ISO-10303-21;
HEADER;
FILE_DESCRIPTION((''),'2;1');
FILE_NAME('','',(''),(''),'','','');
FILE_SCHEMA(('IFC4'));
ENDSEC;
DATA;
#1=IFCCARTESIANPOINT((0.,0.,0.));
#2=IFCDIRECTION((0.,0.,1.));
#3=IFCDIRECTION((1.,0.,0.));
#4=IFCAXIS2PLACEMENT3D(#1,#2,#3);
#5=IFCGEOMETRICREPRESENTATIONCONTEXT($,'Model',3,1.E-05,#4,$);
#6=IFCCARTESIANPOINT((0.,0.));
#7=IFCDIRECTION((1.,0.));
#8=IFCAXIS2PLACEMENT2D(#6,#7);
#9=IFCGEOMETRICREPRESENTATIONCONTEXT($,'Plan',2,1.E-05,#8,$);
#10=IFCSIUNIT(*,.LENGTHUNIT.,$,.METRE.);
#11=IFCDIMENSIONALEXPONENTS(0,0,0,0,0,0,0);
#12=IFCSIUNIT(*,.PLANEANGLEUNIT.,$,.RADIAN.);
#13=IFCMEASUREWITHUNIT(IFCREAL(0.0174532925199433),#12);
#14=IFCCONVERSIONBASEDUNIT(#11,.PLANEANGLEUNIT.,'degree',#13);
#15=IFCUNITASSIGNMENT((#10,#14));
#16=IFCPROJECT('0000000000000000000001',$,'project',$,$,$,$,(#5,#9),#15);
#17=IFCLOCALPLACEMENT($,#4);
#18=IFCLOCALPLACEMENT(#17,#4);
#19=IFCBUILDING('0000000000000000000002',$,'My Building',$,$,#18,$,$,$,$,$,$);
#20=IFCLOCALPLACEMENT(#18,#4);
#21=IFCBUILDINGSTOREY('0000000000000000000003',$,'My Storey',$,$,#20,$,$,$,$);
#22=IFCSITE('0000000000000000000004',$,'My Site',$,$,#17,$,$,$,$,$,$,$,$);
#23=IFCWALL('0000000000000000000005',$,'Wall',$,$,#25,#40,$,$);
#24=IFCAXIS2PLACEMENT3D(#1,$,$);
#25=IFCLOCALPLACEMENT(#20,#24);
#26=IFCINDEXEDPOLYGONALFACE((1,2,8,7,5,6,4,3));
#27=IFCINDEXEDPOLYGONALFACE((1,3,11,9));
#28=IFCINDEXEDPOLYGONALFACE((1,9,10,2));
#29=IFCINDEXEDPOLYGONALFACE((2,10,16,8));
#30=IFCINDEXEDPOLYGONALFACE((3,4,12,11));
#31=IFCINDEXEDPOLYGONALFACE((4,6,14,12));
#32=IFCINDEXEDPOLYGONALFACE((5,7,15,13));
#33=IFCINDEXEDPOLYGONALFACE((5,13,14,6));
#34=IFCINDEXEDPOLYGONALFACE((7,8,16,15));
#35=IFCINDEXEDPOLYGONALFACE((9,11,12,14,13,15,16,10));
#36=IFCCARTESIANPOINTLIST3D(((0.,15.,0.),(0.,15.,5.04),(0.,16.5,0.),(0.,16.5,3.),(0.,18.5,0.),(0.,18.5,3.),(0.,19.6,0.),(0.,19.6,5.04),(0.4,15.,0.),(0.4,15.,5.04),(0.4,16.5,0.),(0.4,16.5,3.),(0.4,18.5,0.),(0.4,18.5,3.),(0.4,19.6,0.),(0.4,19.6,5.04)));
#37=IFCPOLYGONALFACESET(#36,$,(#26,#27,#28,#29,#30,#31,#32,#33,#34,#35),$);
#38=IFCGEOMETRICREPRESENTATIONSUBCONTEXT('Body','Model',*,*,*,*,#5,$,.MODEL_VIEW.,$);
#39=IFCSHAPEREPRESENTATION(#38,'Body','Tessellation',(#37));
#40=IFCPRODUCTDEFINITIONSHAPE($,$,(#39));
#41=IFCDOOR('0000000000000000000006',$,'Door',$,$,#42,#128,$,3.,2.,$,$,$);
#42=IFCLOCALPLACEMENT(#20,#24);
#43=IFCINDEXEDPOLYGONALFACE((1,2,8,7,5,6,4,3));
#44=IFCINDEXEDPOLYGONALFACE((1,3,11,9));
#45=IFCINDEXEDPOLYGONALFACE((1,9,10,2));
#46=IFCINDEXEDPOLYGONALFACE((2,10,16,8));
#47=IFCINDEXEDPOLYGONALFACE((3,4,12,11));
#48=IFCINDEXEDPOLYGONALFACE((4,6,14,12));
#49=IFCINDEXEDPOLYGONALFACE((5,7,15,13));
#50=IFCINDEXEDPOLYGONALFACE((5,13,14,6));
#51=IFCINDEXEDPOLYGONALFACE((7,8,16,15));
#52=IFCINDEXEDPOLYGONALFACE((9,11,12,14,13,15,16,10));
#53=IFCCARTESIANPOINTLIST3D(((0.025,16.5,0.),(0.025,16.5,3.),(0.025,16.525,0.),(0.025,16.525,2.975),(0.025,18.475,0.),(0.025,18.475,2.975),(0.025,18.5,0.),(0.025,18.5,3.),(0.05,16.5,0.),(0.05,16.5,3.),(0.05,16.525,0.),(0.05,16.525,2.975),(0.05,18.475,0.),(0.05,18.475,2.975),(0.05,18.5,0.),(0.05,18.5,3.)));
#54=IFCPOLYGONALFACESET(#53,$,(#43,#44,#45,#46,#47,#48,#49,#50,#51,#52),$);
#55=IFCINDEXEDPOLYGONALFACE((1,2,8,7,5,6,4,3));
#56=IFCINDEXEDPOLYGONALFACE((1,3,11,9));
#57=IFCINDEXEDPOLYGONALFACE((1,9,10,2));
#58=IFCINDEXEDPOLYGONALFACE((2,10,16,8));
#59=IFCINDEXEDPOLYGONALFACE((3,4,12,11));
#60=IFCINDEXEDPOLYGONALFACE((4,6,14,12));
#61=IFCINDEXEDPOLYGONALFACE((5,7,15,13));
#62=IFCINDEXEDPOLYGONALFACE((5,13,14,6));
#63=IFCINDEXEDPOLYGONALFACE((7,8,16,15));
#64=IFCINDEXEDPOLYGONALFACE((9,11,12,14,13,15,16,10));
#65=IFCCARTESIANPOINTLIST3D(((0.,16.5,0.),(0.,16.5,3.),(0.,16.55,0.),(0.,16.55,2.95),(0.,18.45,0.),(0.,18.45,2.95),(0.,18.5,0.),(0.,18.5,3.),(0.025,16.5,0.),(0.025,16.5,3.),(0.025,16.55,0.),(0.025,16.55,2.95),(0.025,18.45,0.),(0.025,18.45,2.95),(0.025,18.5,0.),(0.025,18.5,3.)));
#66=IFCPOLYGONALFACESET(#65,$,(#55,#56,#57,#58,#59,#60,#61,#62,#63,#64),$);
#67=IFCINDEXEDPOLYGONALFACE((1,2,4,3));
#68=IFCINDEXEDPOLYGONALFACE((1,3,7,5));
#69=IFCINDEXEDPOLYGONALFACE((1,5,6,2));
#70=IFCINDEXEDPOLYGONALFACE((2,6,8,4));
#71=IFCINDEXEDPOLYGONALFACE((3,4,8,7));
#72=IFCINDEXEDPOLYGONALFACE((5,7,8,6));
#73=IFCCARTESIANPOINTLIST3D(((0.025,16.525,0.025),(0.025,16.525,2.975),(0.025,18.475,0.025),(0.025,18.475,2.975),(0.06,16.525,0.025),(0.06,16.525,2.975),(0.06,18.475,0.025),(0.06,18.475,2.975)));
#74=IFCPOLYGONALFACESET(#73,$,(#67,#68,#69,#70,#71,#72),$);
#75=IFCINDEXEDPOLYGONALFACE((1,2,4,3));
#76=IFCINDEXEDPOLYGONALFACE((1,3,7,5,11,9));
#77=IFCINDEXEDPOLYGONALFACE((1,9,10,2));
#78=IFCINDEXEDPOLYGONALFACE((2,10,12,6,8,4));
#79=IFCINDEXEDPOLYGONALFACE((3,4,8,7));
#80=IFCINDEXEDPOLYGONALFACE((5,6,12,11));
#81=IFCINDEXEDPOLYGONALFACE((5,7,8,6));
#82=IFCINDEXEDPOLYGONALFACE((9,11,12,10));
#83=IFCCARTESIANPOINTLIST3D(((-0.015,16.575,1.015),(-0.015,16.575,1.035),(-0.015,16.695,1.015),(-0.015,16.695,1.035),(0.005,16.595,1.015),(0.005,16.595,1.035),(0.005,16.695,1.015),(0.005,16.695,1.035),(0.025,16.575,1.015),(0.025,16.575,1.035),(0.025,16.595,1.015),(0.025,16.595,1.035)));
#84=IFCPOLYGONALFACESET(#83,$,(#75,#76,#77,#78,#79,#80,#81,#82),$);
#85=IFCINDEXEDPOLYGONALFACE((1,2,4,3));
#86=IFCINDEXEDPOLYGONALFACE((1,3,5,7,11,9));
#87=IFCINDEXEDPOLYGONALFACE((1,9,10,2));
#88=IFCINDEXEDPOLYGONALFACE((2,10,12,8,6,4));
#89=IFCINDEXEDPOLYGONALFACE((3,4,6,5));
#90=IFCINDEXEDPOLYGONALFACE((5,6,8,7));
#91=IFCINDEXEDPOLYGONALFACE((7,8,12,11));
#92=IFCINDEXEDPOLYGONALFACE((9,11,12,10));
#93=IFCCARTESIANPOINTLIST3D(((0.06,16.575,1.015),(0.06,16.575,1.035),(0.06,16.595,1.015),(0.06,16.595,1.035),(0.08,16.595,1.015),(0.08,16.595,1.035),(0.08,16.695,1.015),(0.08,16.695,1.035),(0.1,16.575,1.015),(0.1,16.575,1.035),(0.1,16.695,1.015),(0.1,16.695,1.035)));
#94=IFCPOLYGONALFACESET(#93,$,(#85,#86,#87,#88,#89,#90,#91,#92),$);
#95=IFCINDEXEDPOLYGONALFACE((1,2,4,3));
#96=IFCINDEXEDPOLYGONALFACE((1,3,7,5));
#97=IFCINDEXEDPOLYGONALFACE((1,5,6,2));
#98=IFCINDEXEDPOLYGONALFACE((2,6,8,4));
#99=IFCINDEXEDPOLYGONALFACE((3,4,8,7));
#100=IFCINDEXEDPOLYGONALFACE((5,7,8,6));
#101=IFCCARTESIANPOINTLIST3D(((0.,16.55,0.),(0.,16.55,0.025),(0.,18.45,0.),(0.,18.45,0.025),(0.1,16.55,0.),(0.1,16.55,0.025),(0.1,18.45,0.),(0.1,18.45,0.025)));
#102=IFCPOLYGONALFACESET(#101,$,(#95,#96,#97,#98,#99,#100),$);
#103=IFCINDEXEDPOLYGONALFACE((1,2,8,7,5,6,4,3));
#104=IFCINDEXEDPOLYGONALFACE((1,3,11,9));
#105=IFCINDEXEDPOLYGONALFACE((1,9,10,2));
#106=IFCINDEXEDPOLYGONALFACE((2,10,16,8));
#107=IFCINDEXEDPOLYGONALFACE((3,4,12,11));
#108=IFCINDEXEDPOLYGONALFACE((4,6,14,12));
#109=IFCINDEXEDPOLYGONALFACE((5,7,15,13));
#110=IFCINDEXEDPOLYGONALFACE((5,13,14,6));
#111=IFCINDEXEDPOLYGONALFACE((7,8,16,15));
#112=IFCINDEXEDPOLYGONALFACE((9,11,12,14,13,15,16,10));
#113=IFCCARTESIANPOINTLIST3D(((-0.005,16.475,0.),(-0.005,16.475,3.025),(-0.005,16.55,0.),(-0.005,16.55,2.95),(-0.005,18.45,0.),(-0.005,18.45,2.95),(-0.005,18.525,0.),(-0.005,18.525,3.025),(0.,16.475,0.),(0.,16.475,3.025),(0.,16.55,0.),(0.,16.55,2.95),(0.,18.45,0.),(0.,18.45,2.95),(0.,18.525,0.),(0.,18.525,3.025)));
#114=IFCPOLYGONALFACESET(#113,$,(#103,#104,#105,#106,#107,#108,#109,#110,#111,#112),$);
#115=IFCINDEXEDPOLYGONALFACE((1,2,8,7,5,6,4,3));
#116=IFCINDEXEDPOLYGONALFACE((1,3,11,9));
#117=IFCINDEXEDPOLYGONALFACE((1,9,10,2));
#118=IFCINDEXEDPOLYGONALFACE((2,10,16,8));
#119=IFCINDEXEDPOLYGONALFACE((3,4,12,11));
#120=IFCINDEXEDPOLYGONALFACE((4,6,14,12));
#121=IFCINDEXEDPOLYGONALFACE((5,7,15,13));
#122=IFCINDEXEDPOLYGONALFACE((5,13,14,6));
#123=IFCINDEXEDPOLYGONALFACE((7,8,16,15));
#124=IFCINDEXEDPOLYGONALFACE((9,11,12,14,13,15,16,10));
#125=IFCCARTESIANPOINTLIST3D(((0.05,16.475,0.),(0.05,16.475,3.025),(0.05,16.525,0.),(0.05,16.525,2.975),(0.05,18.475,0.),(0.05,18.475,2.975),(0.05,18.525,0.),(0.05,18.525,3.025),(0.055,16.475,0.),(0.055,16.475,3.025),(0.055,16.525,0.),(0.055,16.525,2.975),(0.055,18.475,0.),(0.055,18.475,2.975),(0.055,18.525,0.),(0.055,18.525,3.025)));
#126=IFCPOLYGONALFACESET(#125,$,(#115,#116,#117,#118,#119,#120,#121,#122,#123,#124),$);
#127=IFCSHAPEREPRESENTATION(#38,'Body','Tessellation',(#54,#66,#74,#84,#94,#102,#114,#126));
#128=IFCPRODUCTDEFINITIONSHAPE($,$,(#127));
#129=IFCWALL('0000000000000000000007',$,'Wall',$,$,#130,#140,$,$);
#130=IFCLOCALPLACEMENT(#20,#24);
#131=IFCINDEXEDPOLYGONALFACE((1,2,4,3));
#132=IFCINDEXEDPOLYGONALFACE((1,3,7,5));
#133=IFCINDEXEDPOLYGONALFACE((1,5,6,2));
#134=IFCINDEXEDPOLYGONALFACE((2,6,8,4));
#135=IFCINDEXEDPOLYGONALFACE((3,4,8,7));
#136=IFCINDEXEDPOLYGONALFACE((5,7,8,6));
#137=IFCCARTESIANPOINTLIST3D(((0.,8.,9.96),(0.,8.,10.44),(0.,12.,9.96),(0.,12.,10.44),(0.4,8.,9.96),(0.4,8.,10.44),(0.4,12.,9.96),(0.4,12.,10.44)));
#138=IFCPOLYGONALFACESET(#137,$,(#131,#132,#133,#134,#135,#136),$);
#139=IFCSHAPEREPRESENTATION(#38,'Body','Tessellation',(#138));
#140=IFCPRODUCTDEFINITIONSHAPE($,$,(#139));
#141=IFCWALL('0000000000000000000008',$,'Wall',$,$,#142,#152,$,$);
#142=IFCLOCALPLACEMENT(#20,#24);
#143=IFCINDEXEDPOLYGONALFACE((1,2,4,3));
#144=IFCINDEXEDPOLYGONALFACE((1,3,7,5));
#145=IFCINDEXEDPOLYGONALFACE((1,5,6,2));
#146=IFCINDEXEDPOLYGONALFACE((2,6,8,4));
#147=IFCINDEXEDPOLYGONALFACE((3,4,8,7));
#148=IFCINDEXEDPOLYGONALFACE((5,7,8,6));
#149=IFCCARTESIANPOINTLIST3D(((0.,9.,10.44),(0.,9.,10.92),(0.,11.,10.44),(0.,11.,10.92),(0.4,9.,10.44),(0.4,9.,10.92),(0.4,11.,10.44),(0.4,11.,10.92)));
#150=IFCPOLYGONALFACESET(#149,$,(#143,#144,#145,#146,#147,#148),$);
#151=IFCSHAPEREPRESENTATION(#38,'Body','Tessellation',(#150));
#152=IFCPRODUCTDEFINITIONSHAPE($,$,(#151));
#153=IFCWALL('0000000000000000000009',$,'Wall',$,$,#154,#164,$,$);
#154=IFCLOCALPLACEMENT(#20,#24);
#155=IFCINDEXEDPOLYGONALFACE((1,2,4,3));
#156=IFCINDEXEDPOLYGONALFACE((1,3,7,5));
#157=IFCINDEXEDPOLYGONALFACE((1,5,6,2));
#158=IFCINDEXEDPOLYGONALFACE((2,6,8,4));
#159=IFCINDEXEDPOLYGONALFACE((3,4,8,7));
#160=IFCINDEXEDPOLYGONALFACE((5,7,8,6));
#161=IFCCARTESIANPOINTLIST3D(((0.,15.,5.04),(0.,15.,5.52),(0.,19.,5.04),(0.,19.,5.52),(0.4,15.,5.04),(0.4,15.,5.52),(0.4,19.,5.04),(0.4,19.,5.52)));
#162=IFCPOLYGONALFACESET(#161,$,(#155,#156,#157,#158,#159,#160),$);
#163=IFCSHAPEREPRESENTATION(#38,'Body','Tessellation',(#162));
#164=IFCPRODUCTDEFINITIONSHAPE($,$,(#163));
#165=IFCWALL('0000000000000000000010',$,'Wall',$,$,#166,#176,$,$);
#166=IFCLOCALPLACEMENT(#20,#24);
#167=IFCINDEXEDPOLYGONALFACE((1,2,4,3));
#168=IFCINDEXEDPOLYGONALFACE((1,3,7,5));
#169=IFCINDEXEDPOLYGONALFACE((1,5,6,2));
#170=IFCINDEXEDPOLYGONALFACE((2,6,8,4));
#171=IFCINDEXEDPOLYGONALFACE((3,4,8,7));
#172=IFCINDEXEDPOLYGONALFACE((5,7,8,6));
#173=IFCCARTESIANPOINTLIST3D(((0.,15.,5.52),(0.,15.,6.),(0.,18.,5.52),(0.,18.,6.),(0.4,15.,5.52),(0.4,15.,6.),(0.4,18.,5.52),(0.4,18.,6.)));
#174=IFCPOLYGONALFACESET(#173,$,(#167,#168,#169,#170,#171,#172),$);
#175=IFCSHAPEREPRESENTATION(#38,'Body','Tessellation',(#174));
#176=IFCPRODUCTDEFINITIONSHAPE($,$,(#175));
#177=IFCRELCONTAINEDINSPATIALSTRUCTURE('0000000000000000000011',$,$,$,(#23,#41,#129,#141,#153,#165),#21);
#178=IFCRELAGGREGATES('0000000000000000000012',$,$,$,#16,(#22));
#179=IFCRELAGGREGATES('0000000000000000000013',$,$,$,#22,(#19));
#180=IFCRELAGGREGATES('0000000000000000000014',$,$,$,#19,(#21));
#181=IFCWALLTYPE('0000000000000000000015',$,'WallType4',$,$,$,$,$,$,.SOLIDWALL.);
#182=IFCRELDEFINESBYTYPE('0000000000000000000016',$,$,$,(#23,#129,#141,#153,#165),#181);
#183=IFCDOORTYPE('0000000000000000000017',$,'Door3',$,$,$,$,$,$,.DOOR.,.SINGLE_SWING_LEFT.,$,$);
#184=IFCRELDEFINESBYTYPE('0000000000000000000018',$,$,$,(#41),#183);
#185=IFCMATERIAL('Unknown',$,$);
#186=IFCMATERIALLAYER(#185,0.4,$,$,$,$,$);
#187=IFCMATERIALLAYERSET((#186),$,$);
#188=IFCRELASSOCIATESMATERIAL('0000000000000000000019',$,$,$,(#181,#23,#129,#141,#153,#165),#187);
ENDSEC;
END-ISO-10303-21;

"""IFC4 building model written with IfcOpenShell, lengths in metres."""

from ifc_helpers import new_model, entity, si_unit, converted_unit, frame, origin_with_axes, origin_2d_with_axis, place, context, subcontext, project, spatial, line, indexed_curve, outline, extrude, shape, source, transform, mapped, material, layer, layer_set, layer_usage, type_object, type_shapes, element, fill, save


model = new_model("IFC4")

# Units and contexts
model_context = context("Model", 3, precision=1e-05, world=origin_with_axes())
plan_context = context("Plan", 2, precision=1e-05, world=origin_2d_with_axis())
body_context_1 = subcontext(model_context, "Body", "Model", "MODEL_VIEW")
body_context_2 = subcontext(plan_context, "Body", "Plan", "PLAN_VIEW")
ifc_project = project(units=[si_unit("LENGTHUNIT", "METRE"), converted_unit("PLANEANGLEUNIT", "degree", entity("IfcReal", 0.0174532925199433), si_unit("PLANEANGLEUNIT", "RADIAN"), dimensions=[0, 0, 0, 0, 0, 0, 0])], contexts=[model_context, plan_context])

# Site, building, storey
site_placement = place(None, origin_with_axes())
site = spatial("IfcSite", under=ifc_project, at=site_placement, Name="My Site")
building_placement = place(site_placement, origin_with_axes())
building = spatial("IfcBuilding", under=site, at=building_placement, Name="My Building")
storey_placement = place(building_placement, origin_with_axes())
storey = spatial("IfcBuildingStorey", under=building, at=storey_placement, Name="My Storey")

# Shared definitions
ifc_material = material(Name="Unknown")

# Shared definitions
ifc_layer_1 = layer(ifc_material, 0.4)
ifc_layer_set_1 = layer_set([ifc_layer_1])
wall_type_1 = type_object("IfcWallType", Name="WallType4", PredefinedType="SOLIDWALL", material=ifc_layer_set_1)

# Wall, opening, door
ifc_layer_usage_1 = layer_usage(ifc_layer_set_1, "AXIS2", "POSITIVE", 0.0)
wall_1_placement = place(storey_placement, frame((0.0, 19.6, 0.0), z_axis=(0.0, 0.0, 1.0), x_axis=(0.0, -1.0, 0.0)))
wall_1 = element("IfcWall", 1, at=wall_1_placement, inside=storey, type_object=wall_type_1, material=ifc_layer_usage_1, Name="Wall", context=body_context_1, shape_type="SweptSolid", body=[
    extrude(outline(indexed_curve([(0.0, 0.0), (0.0, 0.4), (4.6, 0.4), (4.6, 0.0), (0.0, 0.0)], self_intersect=False)), origin_with_axes(), (0.0, 0.0, 1.0), 5.04),
])
shared_shape_1 = source(origin_with_axes(), body_context_1, "Body", "SweptSolid", [
    extrude(outline(indexed_curve([(0.0, 0.0), (2.0, 0.0), (2.0, 3.0), (0.0, 3.0)], segments=[line(1, 2, 3, 4, 1)])), frame((0.0, -0.6, 0.0), z_axis=(0.0, -1.0, 0.0), x_axis=(1.0, 0.0, 0.0)), (0.0, 0.0, -1.0), 1.2),
])
opening_1_placement = place(wall_1_placement, frame((1.1, 0.0, 0.0), z_axis=(0.0, 0.0, 1.0), x_axis=(1.0, 0.0, 0.0)))
opening_1 = element("IfcOpeningElement", 2, at=opening_1_placement, cuts=wall_1, PredefinedType="OPENING", context=body_context_1, shape_type="MappedRepresentation", body=[
    mapped(shared_shape_1, transform((0.0, 0.0, 0.0), x_axis=(1.0, 0.0, 0.0), y_axis=(0.0, 1.0, 0.0), z_axis=(0.0, 0.0, 1.0), scale=1.0)),
])
door_type_1 = type_object("IfcDoorType", Name="Door3", OperationType="SINGLE_SWING_LEFT", PredefinedType="DOOR")
shared_shape_2 = source(origin_with_axes(), body_context_1, "Body", "SweptSolid", [
    extrude(outline(indexed_curve([(0.0, 0.0), (0.0, 3.0), (2.0, 3.0), (2.0, 0.0), (1.975, 0.0), (1.975, 2.975), (0.025, 2.975), (0.025, 0.0)], segments=[line(1, 2, 3, 4, 5, 6, 7, 8, 1)])), frame((0.0, 0.025, 0.0), z_axis=(0.0, -1.0, 0.0), x_axis=(1.0, 0.0, 0.0)), (0.0, 0.0, -1.0), 0.025),
    extrude(outline(indexed_curve([(0.0, 0.0), (0.0, 3.0), (2.0, 3.0), (2.0, 0.0), (1.95, 0.0), (1.95, 2.95), (0.05, 2.95), (0.05, 0.0)], segments=[line(1, 2, 3, 4, 5, 6, 7, 8, 1)])), frame((0.0, 0.0, 0.0), z_axis=(0.0, -1.0, 0.0), x_axis=(1.0, 0.0, 0.0)), (0.0, 0.0, -1.0), 0.025),
    extrude(outline(indexed_curve([(0.0, 0.0), (1.95, 0.0), (1.95, 0.035), (0.0, 0.035)], segments=[line(1, 2, 3, 4, 1)])), frame((0.025, 0.025, 0.025), z_axis=(0.0, 0.0, 1.0), x_axis=(1.0, 0.0, 0.0)), (0.0, 0.0, 1.0), 2.95),
    extrude(outline(indexed_curve([(0.0, 0.0), (0.0, -0.04), (-0.12, -0.04), (-0.12, -0.02), (-0.02, -0.02), (-0.02, 0.0)], segments=[line(1, 2, 3, 4, 5, 6, 1)])), frame((1.925, 0.025, 1.015), z_axis=(0.0, 0.0, 1.0), x_axis=(1.0, 0.0, 0.0)), (0.0, 0.0, 1.0), 0.02),
    extrude(outline(indexed_curve([(0.0, 0.0), (0.0, 0.04), (-0.12, 0.04), (-0.12, 0.02), (-0.02, 0.02), (-0.02, 0.0)], segments=[line(1, 2, 3, 4, 5, 6, 1)])), frame((1.925, 0.06, 1.015), z_axis=(0.0, 0.0, 1.0), x_axis=(1.0, 0.0, 0.0)), (0.0, 0.0, 1.0), 0.02),
    extrude(outline(indexed_curve([(0.0, 0.0), (1.9, 0.0), (1.9, 0.1), (0.0, 0.1)], segments=[line(1, 2, 3, 4, 1)])), frame((0.05, 0.0, 0.0), z_axis=(0.0, 0.0, 1.0), x_axis=(1.0, 0.0, 0.0)), (0.0, 0.0, 1.0), 0.025),
    extrude(outline(indexed_curve([(0.0, 0.0), (0.0, 3.025), (2.05, 3.025), (2.05, 0.0), (1.975, 0.0), (1.975, 2.95), (0.075, 2.95), (0.075, 0.0)], segments=[line(1, 2, 3, 4, 5, 6, 7, 8, 1)])), frame((-0.025, -0.005, 0.0), z_axis=(0.0, -1.0, 0.0), x_axis=(1.0, 0.0, 0.0)), (0.0, 0.0, -1.0), 0.005),
    extrude(outline(indexed_curve([(0.0, 0.0), (0.0, 3.025), (2.05, 3.025), (2.05, 0.0), (2.0, 0.0), (2.0, 2.975), (0.05, 2.975), (0.05, 0.0)], segments=[line(1, 2, 3, 4, 5, 6, 7, 8, 1)])), frame((-0.025, 0.05, 0.0), z_axis=(0.0, -1.0, 0.0), x_axis=(1.0, 0.0, 0.0)), (0.0, 0.0, -1.0), 0.005),
])
shared_shape_3 = source(origin_with_axes(), body_context_2, "Body", "Curve2D", [
    entity("IfcIndexedPolyCurve", entity("IfcCartesianPointList2D", [[0.0, 0.0], [0.0, 0.05], [0.025, 0.05], [0.025, 0.025], [0.05, 0.025], [0.05, 0.0]]), [entity("IfcLineIndex", [1, 2, 3, 4, 5, 6, 1])]),
    entity("IfcIndexedPolyCurve", entity("IfcCartesianPointList2D", [[2.0, 0.0], [2.0, 0.05], [1.975, 0.05], [1.975, 0.025], [1.95, 0.025], [1.95, 0.0]]), [entity("IfcLineIndex", [1, 2, 3, 4, 5, 6, 1])]),
    entity("IfcTrimmedCurve", entity("IfcEllipse", entity("IfcAxis2Placement2D", entity("IfcCartesianPoint", [0.06, 0.05]), entity("IfcDirection", [1.0, 0.0])), 1.915, 1.95), [entity("IfcCartesianPoint", [1.975, 0.05])], [entity("IfcCartesianPoint", [0.06, 2.0])], True, "CARTESIAN"),
    entity("IfcIndexedPolyCurve", entity("IfcCartesianPointList2D", [[0.025, 0.05], [0.06, 0.05], [0.06, 2.0], [0.025, 2.0]]), [entity("IfcLineIndex", [1, 2, 3, 4, 1])]),
])
type_shapes(door_type_1, [shared_shape_2, shared_shape_3])
door_1_placement = place(opening_1_placement, origin_with_axes())
door_1 = element("IfcDoor", 3, at=door_1_placement, inside=storey, type_object=door_type_1, Name="Door", OverallHeight=3.0, OverallWidth=2.0, shapes=[
    shape(body_context_1, "Body", "MappedRepresentation", [mapped(shared_shape_2, transform((0.0, 0.0, 0.0), x_axis=(1.0, 0.0, 0.0), y_axis=(0.0, 1.0, 0.0), z_axis=(0.0, 0.0, 1.0), scale=1.0))]),
    shape(body_context_2, "Body", "MappedRepresentation", [mapped(shared_shape_3, transform((0.0, 0.0, 0.0), x_axis=(1.0, 0.0, 0.0), y_axis=(0.0, 1.0, 0.0), z_axis=(0.0, 0.0, 1.0), scale=1.0))]),
])
fill(opening_1, door_1)

# Walls
ifc_layer_usage_2 = layer_usage(ifc_layer_set_1, "AXIS2", "POSITIVE", 0.0)
wall_2_placement = place(storey_placement, frame((0.4, 8.0, 9.96), z_axis=(0.0, 0.0, 1.0), x_axis=(0.0, 1.0, 0.0)))
element("IfcWall", 4, at=wall_2_placement, inside=storey, type_object=wall_type_1, material=ifc_layer_usage_2, Name="Wall", context=body_context_1, shape_type="SweptSolid", body=[
    extrude(outline(indexed_curve([(0.0, 0.0), (0.0, 0.4), (4.0, 0.4), (4.0, 0.0), (0.0, 0.0)], self_intersect=False)), origin_with_axes(), (0.0, 0.0, 1.0), 0.48),
])
ifc_layer_usage_3 = layer_usage(ifc_layer_set_1, "AXIS2", "POSITIVE", 0.0)
wall_3_placement = place(storey_placement, frame((0.4, 9.0, 10.44), z_axis=(0.0, 0.0, 1.0), x_axis=(0.0, 1.0, 0.0)))
element("IfcWall", 5, at=wall_3_placement, inside=storey, type_object=wall_type_1, material=ifc_layer_usage_3, Name="Wall", context=body_context_1, shape_type="SweptSolid", body=[
    extrude(outline(indexed_curve([(0.0, 0.0), (0.0, 0.4), (2.0, 0.4), (2.0, 0.0), (0.0, 0.0)], self_intersect=False)), origin_with_axes(), (0.0, 0.0, 1.0), 0.48),
])
ifc_layer_usage_4 = layer_usage(ifc_layer_set_1, "AXIS2", "POSITIVE", 0.0)
wall_4_placement = place(storey_placement, frame((0.4, 15.0, 5.04), z_axis=(0.0, 0.0, 1.0), x_axis=(0.0, 1.0, 0.0)))
element("IfcWall", 6, at=wall_4_placement, inside=storey, type_object=wall_type_1, material=ifc_layer_usage_4, Name="Wall", context=body_context_1, shape_type="SweptSolid", body=[
    extrude(outline(indexed_curve([(0.0, 0.0), (0.0, 0.4), (4.0, 0.4), (4.0, 0.0), (0.0, 0.0)], self_intersect=False)), origin_with_axes(), (0.0, 0.0, 1.0), 0.48),
])
ifc_layer_usage_5 = layer_usage(ifc_layer_set_1, "AXIS2", "POSITIVE", 0.0)
wall_5_placement = place(storey_placement, frame((0.4, 15.0, 5.52), z_axis=(0.0, 0.0, 1.0), x_axis=(0.0, 1.0, 0.0)))
element("IfcWall", 7, at=wall_5_placement, inside=storey, type_object=wall_type_1, material=ifc_layer_usage_5, Name="Wall", context=body_context_1, shape_type="SweptSolid", body=[
    extrude(outline(indexed_curve([(0.0, 0.0), (0.0, 0.4), (3.0, 0.4), (3.0, 0.0), (0.0, 0.0)], self_intersect=False)), origin_with_axes(), (0.0, 0.0, 1.0), 0.48),
])

save(model, "model.ifc")
